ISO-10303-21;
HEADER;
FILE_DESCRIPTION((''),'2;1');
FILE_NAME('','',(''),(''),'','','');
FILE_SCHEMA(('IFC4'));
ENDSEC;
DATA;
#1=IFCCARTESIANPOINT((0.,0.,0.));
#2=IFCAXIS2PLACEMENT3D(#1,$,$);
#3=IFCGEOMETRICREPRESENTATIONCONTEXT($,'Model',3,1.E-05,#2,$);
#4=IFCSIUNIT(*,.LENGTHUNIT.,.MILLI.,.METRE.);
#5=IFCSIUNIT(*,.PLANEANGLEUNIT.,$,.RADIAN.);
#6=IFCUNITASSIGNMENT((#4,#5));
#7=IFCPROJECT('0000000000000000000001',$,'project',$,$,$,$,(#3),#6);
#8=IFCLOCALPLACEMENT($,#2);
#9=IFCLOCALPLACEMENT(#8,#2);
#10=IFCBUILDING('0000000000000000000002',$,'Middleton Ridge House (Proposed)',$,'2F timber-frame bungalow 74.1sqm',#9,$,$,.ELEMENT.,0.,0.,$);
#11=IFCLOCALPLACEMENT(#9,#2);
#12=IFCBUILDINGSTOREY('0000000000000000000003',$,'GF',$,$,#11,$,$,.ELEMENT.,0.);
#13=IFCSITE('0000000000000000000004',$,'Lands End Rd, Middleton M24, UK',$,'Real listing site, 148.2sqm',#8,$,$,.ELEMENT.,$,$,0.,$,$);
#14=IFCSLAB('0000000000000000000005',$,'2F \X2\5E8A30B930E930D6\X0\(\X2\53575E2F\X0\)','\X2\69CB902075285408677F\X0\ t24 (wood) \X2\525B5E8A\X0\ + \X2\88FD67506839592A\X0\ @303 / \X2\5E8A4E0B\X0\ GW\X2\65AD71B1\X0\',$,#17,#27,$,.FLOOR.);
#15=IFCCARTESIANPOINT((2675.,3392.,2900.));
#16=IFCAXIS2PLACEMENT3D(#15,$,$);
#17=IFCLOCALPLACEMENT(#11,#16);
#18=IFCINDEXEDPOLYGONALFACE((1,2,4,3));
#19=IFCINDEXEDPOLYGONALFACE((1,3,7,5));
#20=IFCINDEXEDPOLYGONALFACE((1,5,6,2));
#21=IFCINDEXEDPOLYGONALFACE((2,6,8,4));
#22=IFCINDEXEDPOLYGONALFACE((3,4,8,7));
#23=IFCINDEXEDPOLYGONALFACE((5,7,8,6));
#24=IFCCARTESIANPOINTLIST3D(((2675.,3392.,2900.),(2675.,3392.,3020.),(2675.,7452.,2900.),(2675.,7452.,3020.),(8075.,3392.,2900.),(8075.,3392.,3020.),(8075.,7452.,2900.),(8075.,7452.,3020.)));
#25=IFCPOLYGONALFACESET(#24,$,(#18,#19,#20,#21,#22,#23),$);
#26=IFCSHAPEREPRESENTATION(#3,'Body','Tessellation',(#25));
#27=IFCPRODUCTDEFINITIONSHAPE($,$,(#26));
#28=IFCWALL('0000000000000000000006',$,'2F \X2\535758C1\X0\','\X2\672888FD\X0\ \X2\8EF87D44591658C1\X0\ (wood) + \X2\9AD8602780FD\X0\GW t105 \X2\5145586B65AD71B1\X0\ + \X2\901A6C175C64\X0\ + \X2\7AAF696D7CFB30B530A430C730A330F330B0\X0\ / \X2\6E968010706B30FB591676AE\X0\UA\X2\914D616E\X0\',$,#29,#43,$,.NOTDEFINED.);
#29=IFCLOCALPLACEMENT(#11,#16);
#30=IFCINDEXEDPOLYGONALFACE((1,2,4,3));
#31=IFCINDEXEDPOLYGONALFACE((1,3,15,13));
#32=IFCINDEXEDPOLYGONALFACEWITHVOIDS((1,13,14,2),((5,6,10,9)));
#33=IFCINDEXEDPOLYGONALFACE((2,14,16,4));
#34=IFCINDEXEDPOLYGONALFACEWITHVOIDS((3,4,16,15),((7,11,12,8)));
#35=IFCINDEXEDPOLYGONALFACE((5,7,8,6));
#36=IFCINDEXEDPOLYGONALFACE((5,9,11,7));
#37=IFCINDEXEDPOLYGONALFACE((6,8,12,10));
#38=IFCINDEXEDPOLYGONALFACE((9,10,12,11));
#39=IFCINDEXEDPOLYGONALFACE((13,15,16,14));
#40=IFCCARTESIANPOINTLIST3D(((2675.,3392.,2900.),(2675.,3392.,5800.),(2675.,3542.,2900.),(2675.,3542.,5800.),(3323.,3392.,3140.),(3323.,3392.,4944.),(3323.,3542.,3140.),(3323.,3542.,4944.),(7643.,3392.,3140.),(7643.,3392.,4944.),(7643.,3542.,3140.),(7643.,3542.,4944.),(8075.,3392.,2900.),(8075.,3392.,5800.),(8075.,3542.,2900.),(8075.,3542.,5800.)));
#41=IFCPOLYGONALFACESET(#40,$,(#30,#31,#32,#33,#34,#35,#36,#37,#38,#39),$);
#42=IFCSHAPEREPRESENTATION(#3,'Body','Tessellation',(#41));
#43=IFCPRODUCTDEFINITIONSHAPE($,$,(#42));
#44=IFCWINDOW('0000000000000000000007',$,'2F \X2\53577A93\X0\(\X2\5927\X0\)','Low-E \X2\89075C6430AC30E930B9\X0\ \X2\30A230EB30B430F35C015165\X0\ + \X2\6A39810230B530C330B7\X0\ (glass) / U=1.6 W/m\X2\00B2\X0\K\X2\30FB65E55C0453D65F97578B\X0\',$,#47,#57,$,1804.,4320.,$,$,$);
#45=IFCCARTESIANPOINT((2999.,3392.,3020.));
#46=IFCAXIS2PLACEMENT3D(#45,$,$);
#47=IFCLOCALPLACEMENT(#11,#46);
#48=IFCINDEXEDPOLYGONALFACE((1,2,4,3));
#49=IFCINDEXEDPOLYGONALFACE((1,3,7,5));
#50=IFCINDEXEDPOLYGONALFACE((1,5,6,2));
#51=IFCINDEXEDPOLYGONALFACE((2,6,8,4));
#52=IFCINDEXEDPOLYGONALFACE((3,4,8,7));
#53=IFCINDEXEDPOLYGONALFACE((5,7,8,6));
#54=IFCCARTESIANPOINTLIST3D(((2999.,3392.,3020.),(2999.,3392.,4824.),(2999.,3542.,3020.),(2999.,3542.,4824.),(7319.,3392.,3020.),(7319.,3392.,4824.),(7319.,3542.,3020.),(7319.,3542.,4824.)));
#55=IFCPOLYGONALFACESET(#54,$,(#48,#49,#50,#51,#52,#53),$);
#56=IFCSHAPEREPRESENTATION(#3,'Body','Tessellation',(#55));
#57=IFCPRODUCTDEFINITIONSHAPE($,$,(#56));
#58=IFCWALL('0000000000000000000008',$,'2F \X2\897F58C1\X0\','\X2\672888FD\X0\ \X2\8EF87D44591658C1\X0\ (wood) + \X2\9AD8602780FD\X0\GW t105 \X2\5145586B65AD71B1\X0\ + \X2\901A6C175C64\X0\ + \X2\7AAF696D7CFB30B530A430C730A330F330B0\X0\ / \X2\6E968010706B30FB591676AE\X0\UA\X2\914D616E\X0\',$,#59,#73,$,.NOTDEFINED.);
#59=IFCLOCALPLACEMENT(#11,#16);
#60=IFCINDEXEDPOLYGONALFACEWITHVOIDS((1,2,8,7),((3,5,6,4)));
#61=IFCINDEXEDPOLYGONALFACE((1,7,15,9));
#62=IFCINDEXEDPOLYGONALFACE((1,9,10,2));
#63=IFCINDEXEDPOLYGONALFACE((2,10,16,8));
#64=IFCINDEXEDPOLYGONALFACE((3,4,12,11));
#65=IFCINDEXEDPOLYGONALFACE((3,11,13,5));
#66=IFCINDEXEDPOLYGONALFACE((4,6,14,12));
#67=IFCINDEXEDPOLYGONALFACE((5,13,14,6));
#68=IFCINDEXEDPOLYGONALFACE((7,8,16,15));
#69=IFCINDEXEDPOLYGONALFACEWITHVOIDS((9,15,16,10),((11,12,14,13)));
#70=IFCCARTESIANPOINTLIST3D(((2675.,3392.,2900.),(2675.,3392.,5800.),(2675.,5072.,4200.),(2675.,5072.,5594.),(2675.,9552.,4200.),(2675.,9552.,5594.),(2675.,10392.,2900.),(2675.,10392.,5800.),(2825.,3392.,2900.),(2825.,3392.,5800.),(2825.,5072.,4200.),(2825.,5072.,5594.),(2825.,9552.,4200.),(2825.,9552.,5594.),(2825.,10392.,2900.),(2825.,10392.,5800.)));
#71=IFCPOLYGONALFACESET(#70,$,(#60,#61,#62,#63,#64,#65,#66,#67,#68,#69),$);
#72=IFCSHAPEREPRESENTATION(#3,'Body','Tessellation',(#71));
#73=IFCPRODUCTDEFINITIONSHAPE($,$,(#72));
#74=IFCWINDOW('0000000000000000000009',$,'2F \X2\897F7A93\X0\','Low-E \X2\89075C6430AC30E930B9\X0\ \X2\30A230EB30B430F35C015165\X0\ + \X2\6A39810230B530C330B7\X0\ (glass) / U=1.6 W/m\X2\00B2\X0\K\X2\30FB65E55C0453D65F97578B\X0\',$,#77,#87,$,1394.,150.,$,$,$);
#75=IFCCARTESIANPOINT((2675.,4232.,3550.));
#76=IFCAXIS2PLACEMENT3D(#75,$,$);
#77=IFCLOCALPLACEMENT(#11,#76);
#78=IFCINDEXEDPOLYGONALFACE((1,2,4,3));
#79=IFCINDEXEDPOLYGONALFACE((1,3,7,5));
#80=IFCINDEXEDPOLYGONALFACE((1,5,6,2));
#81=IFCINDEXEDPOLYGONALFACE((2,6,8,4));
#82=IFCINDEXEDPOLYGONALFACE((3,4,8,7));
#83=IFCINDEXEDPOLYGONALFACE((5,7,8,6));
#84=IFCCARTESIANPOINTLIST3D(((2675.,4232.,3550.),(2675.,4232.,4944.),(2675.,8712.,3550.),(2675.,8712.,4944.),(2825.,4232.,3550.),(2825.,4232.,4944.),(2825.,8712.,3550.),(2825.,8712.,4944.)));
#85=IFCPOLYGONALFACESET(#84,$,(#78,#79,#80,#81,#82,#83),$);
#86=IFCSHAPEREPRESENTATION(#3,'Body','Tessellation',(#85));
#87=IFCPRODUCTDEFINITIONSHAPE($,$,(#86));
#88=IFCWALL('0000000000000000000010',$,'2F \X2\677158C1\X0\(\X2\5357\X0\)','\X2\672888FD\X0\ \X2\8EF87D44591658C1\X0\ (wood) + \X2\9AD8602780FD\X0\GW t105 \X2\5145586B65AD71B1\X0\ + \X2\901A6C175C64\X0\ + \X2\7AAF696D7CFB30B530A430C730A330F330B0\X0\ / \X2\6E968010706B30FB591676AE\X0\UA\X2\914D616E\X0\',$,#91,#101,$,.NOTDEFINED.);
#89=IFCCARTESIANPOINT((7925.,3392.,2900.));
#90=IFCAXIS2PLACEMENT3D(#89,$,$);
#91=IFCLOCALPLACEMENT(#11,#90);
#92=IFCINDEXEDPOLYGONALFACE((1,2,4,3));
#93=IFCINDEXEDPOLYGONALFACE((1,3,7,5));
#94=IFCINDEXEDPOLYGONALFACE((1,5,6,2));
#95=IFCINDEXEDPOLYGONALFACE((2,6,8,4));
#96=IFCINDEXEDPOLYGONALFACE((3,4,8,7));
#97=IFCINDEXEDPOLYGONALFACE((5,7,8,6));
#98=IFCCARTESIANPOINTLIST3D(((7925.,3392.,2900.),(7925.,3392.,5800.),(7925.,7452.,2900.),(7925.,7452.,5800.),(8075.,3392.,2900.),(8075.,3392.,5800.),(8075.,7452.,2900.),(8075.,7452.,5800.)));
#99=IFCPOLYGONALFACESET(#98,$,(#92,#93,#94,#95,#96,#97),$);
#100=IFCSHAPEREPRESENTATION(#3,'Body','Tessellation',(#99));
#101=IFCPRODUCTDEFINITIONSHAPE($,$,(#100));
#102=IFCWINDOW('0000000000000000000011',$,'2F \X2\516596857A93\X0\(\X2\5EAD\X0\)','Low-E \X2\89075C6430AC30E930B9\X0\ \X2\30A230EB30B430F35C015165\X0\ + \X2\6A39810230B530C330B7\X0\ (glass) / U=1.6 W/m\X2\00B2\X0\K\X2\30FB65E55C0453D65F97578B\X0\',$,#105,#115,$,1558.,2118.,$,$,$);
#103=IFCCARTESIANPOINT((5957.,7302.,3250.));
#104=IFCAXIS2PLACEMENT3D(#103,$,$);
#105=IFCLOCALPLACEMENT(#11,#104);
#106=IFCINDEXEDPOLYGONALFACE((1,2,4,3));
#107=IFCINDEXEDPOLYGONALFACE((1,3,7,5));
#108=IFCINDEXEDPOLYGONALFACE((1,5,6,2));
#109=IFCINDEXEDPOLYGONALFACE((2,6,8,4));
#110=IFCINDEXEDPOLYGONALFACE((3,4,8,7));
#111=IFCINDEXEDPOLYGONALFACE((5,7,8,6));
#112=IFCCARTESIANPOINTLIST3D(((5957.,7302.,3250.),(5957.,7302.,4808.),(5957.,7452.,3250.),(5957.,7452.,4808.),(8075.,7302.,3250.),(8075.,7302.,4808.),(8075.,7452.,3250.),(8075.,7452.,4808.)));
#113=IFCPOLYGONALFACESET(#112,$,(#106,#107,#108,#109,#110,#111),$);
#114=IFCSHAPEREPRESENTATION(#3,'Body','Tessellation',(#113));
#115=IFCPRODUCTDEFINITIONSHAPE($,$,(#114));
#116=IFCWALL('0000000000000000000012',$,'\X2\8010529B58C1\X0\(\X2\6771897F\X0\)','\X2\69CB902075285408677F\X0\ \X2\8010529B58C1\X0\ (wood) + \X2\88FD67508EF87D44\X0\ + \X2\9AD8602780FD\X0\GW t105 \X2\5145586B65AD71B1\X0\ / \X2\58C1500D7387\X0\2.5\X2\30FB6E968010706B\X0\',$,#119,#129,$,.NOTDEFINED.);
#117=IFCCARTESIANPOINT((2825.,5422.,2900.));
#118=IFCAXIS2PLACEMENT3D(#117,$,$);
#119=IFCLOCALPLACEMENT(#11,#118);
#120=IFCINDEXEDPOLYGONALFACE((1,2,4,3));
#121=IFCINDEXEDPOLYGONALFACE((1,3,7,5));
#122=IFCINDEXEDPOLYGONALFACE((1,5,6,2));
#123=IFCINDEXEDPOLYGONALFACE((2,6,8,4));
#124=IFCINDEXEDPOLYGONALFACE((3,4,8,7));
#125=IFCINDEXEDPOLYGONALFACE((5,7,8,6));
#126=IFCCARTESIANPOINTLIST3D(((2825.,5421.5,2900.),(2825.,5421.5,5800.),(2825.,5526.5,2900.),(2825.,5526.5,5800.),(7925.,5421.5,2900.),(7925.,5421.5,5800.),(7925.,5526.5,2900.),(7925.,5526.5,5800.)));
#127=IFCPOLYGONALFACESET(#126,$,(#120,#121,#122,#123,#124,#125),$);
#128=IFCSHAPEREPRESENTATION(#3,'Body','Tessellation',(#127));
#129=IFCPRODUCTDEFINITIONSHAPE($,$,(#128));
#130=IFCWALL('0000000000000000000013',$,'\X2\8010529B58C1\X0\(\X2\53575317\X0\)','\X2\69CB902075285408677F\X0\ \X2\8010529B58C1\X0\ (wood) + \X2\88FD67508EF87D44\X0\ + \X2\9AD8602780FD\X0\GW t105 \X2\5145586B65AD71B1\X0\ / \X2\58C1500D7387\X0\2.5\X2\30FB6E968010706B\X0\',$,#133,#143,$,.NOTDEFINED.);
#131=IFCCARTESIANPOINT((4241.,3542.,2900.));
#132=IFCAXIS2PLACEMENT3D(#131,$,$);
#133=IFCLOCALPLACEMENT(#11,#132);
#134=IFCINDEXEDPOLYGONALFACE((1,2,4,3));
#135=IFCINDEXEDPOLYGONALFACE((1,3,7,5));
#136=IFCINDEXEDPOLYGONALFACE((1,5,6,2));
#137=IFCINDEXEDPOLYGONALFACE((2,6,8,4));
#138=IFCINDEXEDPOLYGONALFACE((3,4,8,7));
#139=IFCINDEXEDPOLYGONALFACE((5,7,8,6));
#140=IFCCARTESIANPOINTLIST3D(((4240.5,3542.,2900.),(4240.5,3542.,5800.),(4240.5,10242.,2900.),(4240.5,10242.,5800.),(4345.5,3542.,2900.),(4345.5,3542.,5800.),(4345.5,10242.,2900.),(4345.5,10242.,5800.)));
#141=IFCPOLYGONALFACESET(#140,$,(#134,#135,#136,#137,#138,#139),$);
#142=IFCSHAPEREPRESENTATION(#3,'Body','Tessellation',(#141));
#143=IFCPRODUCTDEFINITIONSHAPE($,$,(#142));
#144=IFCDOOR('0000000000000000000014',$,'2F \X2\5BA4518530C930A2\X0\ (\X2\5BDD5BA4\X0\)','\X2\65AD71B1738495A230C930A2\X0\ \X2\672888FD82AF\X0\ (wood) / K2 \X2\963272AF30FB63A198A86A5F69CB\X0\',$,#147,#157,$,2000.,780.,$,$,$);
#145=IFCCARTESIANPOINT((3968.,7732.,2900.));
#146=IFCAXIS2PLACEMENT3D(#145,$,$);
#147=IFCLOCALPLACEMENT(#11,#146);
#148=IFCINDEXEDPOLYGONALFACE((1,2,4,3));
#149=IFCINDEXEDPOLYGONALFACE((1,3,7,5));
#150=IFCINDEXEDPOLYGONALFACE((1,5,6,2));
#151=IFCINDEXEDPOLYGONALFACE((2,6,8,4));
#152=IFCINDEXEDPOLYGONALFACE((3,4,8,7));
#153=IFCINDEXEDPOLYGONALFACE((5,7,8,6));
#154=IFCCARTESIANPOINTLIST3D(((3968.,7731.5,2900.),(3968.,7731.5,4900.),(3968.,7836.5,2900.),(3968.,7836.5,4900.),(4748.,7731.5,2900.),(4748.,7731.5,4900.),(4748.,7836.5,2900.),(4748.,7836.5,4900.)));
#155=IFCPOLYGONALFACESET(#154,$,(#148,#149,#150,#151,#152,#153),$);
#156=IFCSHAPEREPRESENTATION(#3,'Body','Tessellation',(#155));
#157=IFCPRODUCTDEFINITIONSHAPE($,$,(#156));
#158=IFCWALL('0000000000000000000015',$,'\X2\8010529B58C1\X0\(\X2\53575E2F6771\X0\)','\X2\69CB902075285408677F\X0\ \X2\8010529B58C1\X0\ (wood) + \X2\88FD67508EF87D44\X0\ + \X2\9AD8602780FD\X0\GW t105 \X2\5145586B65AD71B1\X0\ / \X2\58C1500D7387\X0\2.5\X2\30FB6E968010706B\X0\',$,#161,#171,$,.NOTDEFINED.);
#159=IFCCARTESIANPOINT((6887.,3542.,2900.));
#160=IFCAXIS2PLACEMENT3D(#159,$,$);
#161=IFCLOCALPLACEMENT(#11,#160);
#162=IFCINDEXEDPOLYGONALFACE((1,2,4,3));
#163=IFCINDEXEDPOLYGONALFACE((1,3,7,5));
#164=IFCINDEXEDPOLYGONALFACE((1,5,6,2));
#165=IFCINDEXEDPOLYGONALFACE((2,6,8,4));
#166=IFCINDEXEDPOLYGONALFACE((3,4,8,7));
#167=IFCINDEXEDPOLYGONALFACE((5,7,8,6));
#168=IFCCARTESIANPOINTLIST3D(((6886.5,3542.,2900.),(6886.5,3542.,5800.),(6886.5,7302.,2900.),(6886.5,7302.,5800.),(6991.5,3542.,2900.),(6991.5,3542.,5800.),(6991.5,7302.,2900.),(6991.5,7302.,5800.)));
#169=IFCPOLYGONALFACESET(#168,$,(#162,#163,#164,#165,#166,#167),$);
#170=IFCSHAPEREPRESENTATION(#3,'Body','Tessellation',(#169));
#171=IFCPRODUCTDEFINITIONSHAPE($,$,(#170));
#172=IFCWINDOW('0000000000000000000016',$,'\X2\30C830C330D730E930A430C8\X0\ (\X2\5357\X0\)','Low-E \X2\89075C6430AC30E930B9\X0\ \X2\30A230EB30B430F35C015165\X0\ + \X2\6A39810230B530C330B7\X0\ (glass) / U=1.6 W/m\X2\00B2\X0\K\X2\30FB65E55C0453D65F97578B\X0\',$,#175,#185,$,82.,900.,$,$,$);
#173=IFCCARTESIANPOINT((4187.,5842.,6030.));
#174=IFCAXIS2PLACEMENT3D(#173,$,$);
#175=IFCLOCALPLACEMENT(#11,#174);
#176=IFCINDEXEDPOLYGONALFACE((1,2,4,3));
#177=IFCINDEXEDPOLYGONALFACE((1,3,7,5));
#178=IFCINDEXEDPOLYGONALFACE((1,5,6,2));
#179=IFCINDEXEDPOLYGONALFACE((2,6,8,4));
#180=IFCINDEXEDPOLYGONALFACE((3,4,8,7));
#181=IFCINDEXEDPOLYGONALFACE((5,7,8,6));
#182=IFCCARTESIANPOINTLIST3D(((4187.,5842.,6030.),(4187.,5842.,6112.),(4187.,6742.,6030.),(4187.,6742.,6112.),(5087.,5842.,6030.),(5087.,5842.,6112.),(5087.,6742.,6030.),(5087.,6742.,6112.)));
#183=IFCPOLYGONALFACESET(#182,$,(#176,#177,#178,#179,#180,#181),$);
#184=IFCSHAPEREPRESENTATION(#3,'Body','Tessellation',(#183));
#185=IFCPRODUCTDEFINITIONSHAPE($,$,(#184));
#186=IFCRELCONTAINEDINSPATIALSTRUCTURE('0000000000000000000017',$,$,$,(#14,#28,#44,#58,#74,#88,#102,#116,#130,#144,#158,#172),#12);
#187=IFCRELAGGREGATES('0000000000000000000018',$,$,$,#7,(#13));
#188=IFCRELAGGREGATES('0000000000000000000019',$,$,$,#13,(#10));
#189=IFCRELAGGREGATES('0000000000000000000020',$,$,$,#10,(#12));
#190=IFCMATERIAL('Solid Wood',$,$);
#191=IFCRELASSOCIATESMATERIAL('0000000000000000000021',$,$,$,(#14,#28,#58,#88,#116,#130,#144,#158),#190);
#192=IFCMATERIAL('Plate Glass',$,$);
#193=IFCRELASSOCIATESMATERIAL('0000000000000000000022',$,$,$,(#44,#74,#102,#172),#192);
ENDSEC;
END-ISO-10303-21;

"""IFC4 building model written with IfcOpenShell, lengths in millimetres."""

from ifc_helpers import new_model, si_unit, frame, frame_2d, origin, place, context, project, spatial, rectangle, extrude, material, element, fill, save


model = new_model("IFC4")

# Units and contexts
model_context = context("Model", 3, precision=1e-05, world=origin())
ifc_project = project(units=[si_unit("LENGTHUNIT", "METRE", prefix="MILLI"), si_unit("PLANEANGLEUNIT", "RADIAN")], contexts=[model_context])

# Site, building, storey
site_placement = place(None, origin())
site = spatial("IfcSite", under=ifc_project, at=site_placement, Name="Lands End Rd, Middleton M24, UK", ObjectType="Real listing site, 148.2sqm", CompositionType="ELEMENT", RefElevation=0.0)
building_placement = place(site_placement, origin())
building = spatial("IfcBuilding", under=site, at=building_placement, Name="Middleton Ridge House (Proposed)", ObjectType="2F timber-frame bungalow 74.1sqm", CompositionType="ELEMENT", ElevationOfRefHeight=0.0, ElevationOfTerrain=0.0)
storey_placement = place(building_placement, origin())
storey = spatial("IfcBuildingStorey", under=building, at=storey_placement, Name="GF", CompositionType="ELEMENT", Elevation=0.0)

# Slab
ifc_material_1 = material(Name="Solid Wood")
slab_placement = place(storey_placement, frame((2675.0, 3392.0, 2900.0)))
element("IfcSlab", 1, at=slab_placement, inside=storey, material=ifc_material_1, Name="2F 床スラブ(南帯)", Description="構造用合板 t24 (wood) 剛床 + 製材根太 @303 / 床下 GW断熱", PredefinedType="FLOOR", context=model_context, shape_type="SweptSolid", body=[
    extrude(rectangle(XDim=5400.0, YDim=4060.0, at=frame_2d((2700.0, 2030.0))), frame((2675.0, 3392.0, 2900.0)), (0.0, 0.0, 1.0), 120.0),
])

# Walls, openings, windows
wall_1_placement = place(storey_placement, frame((2675.0, 3392.0, 2900.0)))
wall_1 = element("IfcWall", 2, at=wall_1_placement, inside=storey, material=ifc_material_1, Name="2F 南壁", Description="木製 軸組外壁 (wood) + 高性能GW t105 充填断熱 + 通気層 + 窯業系サイディング / 準耐火・外皮UA配慮", PredefinedType="NOTDEFINED", context=model_context, shape_type="SweptSolid", body=[
    extrude(rectangle(XDim=5400.0, YDim=150.0, at=frame_2d((2700.0, 75.0))), frame((2675.0, 3392.0, 2900.0)), (0.0, 0.0, 1.0), 2900.0),
])
opening_1_placement = place(storey_placement, frame((2999.0, 3392.0, 3020.0)))
opening_1 = element("IfcOpeningElement", 3, at=opening_1_placement, cuts=wall_1, PredefinedType="NOTDEFINED", context=model_context, shape_type="SweptSolid", body=[
    extrude(rectangle(XDim=4320.0, YDim=150.0, at=frame_2d((2160.0, 75.0))), frame((2999.0, 3392.0, 3020.0)), (0.0, 0.0, 1.0), 1804.0),
])
ifc_material_2 = material(Name="Plate Glass")
window_1_placement = place(storey_placement, frame((2999.0, 3392.0, 3020.0)))
window_1 = element("IfcWindow", 4, at=window_1_placement, inside=storey, material=ifc_material_2, Name="2F 南窓(大)", Description="Low-E 複層ガラス アルゴン封入 + 樹脂サッシ (glass) / U=1.6 W/m²K・日射取得型", OverallHeight=1804.0, OverallWidth=4320.0, context=model_context, shape_type="SweptSolid", body=[
    extrude(rectangle(XDim=4320.0, YDim=150.0, at=frame_2d((2160.0, 75.0))), frame((2999.0, 3392.0, 3020.0)), (0.0, 0.0, 1.0), 1804.0),
])
fill(opening_1, window_1)
wall_2_placement = place(storey_placement, frame((2675.0, 3392.0, 2900.0)))
wall_2 = element("IfcWall", 5, at=wall_2_placement, inside=storey, material=ifc_material_1, Name="2F 西壁", Description="木製 軸組外壁 (wood) + 高性能GW t105 充填断熱 + 通気層 + 窯業系サイディング / 準耐火・外皮UA配慮", PredefinedType="NOTDEFINED", context=model_context, shape_type="SweptSolid", body=[
    extrude(rectangle(XDim=150.0, YDim=7000.0, at=frame_2d((75.0, 3500.0))), frame((2675.0, 3392.0, 2900.0)), (0.0, 0.0, 1.0), 2900.0),
])
opening_2_placement = place(storey_placement, frame((2675.0, 4232.0, 3550.0)))
opening_2 = element("IfcOpeningElement", 6, at=opening_2_placement, cuts=wall_2, PredefinedType="NOTDEFINED", context=model_context, shape_type="SweptSolid", body=[
    extrude(rectangle(XDim=150.0, YDim=4480.0, at=frame_2d((75.0, 2240.0))), frame((2675.0, 4232.0, 3550.0)), (0.0, 0.0, 1.0), 1394.0),
])
window_2_placement = place(storey_placement, frame((2675.0, 4232.0, 3550.0)))
window_2 = element("IfcWindow", 7, at=window_2_placement, inside=storey, material=ifc_material_2, Name="2F 西窓", Description="Low-E 複層ガラス アルゴン封入 + 樹脂サッシ (glass) / U=1.6 W/m²K・日射取得型", OverallHeight=1394.0, OverallWidth=150.0, context=model_context, shape_type="SweptSolid", body=[
    extrude(rectangle(XDim=150.0, YDim=4480.0, at=frame_2d((75.0, 2240.0))), frame((2675.0, 4232.0, 3550.0)), (0.0, 0.0, 1.0), 1394.0),
])
fill(opening_2, window_2)
wall_3_placement = place(storey_placement, frame((7925.0, 3392.0, 2900.0)))
wall_3 = element("IfcWall", 8, at=wall_3_placement, inside=storey, material=ifc_material_1, Name="2F 東壁(南)", Description="木製 軸組外壁 (wood) + 高性能GW t105 充填断熱 + 通気層 + 窯業系サイディング / 準耐火・外皮UA配慮", PredefinedType="NOTDEFINED", context=model_context, shape_type="SweptSolid", body=[
    extrude(rectangle(XDim=150.0, YDim=4060.0, at=frame_2d((75.0, 2030.0))), frame((7925.0, 3392.0, 2900.0)), (0.0, 0.0, 1.0), 2900.0),
])
opening_3_placement = place(storey_placement, frame((5957.0, 7302.0, 3250.0)))
opening_3 = element("IfcOpeningElement", 9, at=opening_3_placement, cuts=wall_3, PredefinedType="NOTDEFINED", context=model_context, shape_type="SweptSolid", body=[
    extrude(rectangle(XDim=2118.0, YDim=150.0, at=frame_2d((1059.0, 75.0))), frame((5957.0, 7302.0, 3250.0)), (0.0, 0.0, 1.0), 1558.0),
])
window_3_placement = place(storey_placement, frame((5957.0, 7302.0, 3250.0)))
window_3 = element("IfcWindow", 10, at=window_3_placement, inside=storey, material=ifc_material_2, Name="2F 入隅窓(庭)", Description="Low-E 複層ガラス アルゴン封入 + 樹脂サッシ (glass) / U=1.6 W/m²K・日射取得型", OverallHeight=1558.0, OverallWidth=2118.0, context=model_context, shape_type="SweptSolid", body=[
    extrude(rectangle(XDim=2118.0, YDim=150.0, at=frame_2d((1059.0, 75.0))), frame((5957.0, 7302.0, 3250.0)), (0.0, 0.0, 1.0), 1558.0),
])
fill(opening_3, window_3)

# Wall
wall_4_placement = place(storey_placement, frame((2825.0, 5422.0, 2900.0)))
element("IfcWall", 11, at=wall_4_placement, inside=storey, material=ifc_material_1, Name="耐力壁(東西)", Description="構造用合板 耐力壁 (wood) + 製材軸組 + 高性能GW t105 充填断熱 / 壁倍率2.5・準耐火", PredefinedType="NOTDEFINED", context=model_context, shape_type="SweptSolid", body=[
    extrude(rectangle(XDim=5100.0, YDim=105.0, at=frame_2d((2550.0, 52.0))), frame((2825.0, 5422.0, 2900.0)), (0.0, 0.0, 1.0), 2900.0),
])

# Wall, opening, door
wall_5_placement = place(storey_placement, frame((4241.0, 3542.0, 2900.0)))
wall_5 = element("IfcWall", 12, at=wall_5_placement, inside=storey, material=ifc_material_1, Name="耐力壁(南北)", Description="構造用合板 耐力壁 (wood) + 製材軸組 + 高性能GW t105 充填断熱 / 壁倍率2.5・準耐火", PredefinedType="NOTDEFINED", context=model_context, shape_type="SweptSolid", body=[
    extrude(rectangle(XDim=105.0, YDim=6700.0, at=frame_2d((52.0, 3350.0))), frame((4241.0, 3542.0, 2900.0)), (0.0, 0.0, 1.0), 2900.0),
])
opening_4_placement = place(storey_placement, frame((3968.0, 7732.0, 2900.0)))
opening_4 = element("IfcOpeningElement", 13, at=opening_4_placement, cuts=wall_5, PredefinedType="NOTDEFINED", context=model_context, shape_type="SweptSolid", body=[
    extrude(rectangle(XDim=780.0, YDim=105.0, at=frame_2d((390.0, 52.0))), frame((3968.0, 7732.0, 2900.0)), (0.0, 0.0, 1.0), 2000.0),
])
door_placement = place(storey_placement, frame((3968.0, 7732.0, 2900.0)))
door = element("IfcDoor", 14, at=door_placement, inside=storey, material=ifc_material_1, Name="2F 室内ドア (寝室)", Description="断熱玄関ドア 木製芯 (wood) / K2 防犯・採風機構", OverallHeight=2000.0, OverallWidth=780.0, context=model_context, shape_type="SweptSolid", body=[
    extrude(rectangle(XDim=780.0, YDim=105.0, at=frame_2d((390.0, 52.0))), frame((3968.0, 7732.0, 2900.0)), (0.0, 0.0, 1.0), 2000.0),
])
fill(opening_4, door)

# Wall
wall_6_placement = place(storey_placement, frame((6887.0, 3542.0, 2900.0)))
element("IfcWall", 15, at=wall_6_placement, inside=storey, material=ifc_material_1, Name="耐力壁(南帯東)", Description="構造用合板 耐力壁 (wood) + 製材軸組 + 高性能GW t105 充填断熱 / 壁倍率2.5・準耐火", PredefinedType="NOTDEFINED", context=model_context, shape_type="SweptSolid", body=[
    extrude(rectangle(XDim=105.0, YDim=3760.0, at=frame_2d((52.0, 1880.0))), frame((6887.0, 3542.0, 2900.0)), (0.0, 0.0, 1.0), 2900.0),
])

# Window
window_4_placement = place(storey_placement, frame((4187.0, 5842.0, 6030.0)))
element("IfcWindow", 16, at=window_4_placement, inside=storey, material=ifc_material_2, Name="トップライト (南)", Description="Low-E 複層ガラス アルゴン封入 + 樹脂サッシ (glass) / U=1.6 W/m²K・日射取得型", OverallHeight=82.0, OverallWidth=900.0, context=model_context, shape_type="SweptSolid", body=[
    extrude(rectangle(XDim=900.0, YDim=900.0, at=frame_2d((450.0, 450.0))), frame((4187.0, 5842.0, 6030.0)), (0.0, 0.0, 1.0), 82.0),
])

save(model, "model.ifc")
